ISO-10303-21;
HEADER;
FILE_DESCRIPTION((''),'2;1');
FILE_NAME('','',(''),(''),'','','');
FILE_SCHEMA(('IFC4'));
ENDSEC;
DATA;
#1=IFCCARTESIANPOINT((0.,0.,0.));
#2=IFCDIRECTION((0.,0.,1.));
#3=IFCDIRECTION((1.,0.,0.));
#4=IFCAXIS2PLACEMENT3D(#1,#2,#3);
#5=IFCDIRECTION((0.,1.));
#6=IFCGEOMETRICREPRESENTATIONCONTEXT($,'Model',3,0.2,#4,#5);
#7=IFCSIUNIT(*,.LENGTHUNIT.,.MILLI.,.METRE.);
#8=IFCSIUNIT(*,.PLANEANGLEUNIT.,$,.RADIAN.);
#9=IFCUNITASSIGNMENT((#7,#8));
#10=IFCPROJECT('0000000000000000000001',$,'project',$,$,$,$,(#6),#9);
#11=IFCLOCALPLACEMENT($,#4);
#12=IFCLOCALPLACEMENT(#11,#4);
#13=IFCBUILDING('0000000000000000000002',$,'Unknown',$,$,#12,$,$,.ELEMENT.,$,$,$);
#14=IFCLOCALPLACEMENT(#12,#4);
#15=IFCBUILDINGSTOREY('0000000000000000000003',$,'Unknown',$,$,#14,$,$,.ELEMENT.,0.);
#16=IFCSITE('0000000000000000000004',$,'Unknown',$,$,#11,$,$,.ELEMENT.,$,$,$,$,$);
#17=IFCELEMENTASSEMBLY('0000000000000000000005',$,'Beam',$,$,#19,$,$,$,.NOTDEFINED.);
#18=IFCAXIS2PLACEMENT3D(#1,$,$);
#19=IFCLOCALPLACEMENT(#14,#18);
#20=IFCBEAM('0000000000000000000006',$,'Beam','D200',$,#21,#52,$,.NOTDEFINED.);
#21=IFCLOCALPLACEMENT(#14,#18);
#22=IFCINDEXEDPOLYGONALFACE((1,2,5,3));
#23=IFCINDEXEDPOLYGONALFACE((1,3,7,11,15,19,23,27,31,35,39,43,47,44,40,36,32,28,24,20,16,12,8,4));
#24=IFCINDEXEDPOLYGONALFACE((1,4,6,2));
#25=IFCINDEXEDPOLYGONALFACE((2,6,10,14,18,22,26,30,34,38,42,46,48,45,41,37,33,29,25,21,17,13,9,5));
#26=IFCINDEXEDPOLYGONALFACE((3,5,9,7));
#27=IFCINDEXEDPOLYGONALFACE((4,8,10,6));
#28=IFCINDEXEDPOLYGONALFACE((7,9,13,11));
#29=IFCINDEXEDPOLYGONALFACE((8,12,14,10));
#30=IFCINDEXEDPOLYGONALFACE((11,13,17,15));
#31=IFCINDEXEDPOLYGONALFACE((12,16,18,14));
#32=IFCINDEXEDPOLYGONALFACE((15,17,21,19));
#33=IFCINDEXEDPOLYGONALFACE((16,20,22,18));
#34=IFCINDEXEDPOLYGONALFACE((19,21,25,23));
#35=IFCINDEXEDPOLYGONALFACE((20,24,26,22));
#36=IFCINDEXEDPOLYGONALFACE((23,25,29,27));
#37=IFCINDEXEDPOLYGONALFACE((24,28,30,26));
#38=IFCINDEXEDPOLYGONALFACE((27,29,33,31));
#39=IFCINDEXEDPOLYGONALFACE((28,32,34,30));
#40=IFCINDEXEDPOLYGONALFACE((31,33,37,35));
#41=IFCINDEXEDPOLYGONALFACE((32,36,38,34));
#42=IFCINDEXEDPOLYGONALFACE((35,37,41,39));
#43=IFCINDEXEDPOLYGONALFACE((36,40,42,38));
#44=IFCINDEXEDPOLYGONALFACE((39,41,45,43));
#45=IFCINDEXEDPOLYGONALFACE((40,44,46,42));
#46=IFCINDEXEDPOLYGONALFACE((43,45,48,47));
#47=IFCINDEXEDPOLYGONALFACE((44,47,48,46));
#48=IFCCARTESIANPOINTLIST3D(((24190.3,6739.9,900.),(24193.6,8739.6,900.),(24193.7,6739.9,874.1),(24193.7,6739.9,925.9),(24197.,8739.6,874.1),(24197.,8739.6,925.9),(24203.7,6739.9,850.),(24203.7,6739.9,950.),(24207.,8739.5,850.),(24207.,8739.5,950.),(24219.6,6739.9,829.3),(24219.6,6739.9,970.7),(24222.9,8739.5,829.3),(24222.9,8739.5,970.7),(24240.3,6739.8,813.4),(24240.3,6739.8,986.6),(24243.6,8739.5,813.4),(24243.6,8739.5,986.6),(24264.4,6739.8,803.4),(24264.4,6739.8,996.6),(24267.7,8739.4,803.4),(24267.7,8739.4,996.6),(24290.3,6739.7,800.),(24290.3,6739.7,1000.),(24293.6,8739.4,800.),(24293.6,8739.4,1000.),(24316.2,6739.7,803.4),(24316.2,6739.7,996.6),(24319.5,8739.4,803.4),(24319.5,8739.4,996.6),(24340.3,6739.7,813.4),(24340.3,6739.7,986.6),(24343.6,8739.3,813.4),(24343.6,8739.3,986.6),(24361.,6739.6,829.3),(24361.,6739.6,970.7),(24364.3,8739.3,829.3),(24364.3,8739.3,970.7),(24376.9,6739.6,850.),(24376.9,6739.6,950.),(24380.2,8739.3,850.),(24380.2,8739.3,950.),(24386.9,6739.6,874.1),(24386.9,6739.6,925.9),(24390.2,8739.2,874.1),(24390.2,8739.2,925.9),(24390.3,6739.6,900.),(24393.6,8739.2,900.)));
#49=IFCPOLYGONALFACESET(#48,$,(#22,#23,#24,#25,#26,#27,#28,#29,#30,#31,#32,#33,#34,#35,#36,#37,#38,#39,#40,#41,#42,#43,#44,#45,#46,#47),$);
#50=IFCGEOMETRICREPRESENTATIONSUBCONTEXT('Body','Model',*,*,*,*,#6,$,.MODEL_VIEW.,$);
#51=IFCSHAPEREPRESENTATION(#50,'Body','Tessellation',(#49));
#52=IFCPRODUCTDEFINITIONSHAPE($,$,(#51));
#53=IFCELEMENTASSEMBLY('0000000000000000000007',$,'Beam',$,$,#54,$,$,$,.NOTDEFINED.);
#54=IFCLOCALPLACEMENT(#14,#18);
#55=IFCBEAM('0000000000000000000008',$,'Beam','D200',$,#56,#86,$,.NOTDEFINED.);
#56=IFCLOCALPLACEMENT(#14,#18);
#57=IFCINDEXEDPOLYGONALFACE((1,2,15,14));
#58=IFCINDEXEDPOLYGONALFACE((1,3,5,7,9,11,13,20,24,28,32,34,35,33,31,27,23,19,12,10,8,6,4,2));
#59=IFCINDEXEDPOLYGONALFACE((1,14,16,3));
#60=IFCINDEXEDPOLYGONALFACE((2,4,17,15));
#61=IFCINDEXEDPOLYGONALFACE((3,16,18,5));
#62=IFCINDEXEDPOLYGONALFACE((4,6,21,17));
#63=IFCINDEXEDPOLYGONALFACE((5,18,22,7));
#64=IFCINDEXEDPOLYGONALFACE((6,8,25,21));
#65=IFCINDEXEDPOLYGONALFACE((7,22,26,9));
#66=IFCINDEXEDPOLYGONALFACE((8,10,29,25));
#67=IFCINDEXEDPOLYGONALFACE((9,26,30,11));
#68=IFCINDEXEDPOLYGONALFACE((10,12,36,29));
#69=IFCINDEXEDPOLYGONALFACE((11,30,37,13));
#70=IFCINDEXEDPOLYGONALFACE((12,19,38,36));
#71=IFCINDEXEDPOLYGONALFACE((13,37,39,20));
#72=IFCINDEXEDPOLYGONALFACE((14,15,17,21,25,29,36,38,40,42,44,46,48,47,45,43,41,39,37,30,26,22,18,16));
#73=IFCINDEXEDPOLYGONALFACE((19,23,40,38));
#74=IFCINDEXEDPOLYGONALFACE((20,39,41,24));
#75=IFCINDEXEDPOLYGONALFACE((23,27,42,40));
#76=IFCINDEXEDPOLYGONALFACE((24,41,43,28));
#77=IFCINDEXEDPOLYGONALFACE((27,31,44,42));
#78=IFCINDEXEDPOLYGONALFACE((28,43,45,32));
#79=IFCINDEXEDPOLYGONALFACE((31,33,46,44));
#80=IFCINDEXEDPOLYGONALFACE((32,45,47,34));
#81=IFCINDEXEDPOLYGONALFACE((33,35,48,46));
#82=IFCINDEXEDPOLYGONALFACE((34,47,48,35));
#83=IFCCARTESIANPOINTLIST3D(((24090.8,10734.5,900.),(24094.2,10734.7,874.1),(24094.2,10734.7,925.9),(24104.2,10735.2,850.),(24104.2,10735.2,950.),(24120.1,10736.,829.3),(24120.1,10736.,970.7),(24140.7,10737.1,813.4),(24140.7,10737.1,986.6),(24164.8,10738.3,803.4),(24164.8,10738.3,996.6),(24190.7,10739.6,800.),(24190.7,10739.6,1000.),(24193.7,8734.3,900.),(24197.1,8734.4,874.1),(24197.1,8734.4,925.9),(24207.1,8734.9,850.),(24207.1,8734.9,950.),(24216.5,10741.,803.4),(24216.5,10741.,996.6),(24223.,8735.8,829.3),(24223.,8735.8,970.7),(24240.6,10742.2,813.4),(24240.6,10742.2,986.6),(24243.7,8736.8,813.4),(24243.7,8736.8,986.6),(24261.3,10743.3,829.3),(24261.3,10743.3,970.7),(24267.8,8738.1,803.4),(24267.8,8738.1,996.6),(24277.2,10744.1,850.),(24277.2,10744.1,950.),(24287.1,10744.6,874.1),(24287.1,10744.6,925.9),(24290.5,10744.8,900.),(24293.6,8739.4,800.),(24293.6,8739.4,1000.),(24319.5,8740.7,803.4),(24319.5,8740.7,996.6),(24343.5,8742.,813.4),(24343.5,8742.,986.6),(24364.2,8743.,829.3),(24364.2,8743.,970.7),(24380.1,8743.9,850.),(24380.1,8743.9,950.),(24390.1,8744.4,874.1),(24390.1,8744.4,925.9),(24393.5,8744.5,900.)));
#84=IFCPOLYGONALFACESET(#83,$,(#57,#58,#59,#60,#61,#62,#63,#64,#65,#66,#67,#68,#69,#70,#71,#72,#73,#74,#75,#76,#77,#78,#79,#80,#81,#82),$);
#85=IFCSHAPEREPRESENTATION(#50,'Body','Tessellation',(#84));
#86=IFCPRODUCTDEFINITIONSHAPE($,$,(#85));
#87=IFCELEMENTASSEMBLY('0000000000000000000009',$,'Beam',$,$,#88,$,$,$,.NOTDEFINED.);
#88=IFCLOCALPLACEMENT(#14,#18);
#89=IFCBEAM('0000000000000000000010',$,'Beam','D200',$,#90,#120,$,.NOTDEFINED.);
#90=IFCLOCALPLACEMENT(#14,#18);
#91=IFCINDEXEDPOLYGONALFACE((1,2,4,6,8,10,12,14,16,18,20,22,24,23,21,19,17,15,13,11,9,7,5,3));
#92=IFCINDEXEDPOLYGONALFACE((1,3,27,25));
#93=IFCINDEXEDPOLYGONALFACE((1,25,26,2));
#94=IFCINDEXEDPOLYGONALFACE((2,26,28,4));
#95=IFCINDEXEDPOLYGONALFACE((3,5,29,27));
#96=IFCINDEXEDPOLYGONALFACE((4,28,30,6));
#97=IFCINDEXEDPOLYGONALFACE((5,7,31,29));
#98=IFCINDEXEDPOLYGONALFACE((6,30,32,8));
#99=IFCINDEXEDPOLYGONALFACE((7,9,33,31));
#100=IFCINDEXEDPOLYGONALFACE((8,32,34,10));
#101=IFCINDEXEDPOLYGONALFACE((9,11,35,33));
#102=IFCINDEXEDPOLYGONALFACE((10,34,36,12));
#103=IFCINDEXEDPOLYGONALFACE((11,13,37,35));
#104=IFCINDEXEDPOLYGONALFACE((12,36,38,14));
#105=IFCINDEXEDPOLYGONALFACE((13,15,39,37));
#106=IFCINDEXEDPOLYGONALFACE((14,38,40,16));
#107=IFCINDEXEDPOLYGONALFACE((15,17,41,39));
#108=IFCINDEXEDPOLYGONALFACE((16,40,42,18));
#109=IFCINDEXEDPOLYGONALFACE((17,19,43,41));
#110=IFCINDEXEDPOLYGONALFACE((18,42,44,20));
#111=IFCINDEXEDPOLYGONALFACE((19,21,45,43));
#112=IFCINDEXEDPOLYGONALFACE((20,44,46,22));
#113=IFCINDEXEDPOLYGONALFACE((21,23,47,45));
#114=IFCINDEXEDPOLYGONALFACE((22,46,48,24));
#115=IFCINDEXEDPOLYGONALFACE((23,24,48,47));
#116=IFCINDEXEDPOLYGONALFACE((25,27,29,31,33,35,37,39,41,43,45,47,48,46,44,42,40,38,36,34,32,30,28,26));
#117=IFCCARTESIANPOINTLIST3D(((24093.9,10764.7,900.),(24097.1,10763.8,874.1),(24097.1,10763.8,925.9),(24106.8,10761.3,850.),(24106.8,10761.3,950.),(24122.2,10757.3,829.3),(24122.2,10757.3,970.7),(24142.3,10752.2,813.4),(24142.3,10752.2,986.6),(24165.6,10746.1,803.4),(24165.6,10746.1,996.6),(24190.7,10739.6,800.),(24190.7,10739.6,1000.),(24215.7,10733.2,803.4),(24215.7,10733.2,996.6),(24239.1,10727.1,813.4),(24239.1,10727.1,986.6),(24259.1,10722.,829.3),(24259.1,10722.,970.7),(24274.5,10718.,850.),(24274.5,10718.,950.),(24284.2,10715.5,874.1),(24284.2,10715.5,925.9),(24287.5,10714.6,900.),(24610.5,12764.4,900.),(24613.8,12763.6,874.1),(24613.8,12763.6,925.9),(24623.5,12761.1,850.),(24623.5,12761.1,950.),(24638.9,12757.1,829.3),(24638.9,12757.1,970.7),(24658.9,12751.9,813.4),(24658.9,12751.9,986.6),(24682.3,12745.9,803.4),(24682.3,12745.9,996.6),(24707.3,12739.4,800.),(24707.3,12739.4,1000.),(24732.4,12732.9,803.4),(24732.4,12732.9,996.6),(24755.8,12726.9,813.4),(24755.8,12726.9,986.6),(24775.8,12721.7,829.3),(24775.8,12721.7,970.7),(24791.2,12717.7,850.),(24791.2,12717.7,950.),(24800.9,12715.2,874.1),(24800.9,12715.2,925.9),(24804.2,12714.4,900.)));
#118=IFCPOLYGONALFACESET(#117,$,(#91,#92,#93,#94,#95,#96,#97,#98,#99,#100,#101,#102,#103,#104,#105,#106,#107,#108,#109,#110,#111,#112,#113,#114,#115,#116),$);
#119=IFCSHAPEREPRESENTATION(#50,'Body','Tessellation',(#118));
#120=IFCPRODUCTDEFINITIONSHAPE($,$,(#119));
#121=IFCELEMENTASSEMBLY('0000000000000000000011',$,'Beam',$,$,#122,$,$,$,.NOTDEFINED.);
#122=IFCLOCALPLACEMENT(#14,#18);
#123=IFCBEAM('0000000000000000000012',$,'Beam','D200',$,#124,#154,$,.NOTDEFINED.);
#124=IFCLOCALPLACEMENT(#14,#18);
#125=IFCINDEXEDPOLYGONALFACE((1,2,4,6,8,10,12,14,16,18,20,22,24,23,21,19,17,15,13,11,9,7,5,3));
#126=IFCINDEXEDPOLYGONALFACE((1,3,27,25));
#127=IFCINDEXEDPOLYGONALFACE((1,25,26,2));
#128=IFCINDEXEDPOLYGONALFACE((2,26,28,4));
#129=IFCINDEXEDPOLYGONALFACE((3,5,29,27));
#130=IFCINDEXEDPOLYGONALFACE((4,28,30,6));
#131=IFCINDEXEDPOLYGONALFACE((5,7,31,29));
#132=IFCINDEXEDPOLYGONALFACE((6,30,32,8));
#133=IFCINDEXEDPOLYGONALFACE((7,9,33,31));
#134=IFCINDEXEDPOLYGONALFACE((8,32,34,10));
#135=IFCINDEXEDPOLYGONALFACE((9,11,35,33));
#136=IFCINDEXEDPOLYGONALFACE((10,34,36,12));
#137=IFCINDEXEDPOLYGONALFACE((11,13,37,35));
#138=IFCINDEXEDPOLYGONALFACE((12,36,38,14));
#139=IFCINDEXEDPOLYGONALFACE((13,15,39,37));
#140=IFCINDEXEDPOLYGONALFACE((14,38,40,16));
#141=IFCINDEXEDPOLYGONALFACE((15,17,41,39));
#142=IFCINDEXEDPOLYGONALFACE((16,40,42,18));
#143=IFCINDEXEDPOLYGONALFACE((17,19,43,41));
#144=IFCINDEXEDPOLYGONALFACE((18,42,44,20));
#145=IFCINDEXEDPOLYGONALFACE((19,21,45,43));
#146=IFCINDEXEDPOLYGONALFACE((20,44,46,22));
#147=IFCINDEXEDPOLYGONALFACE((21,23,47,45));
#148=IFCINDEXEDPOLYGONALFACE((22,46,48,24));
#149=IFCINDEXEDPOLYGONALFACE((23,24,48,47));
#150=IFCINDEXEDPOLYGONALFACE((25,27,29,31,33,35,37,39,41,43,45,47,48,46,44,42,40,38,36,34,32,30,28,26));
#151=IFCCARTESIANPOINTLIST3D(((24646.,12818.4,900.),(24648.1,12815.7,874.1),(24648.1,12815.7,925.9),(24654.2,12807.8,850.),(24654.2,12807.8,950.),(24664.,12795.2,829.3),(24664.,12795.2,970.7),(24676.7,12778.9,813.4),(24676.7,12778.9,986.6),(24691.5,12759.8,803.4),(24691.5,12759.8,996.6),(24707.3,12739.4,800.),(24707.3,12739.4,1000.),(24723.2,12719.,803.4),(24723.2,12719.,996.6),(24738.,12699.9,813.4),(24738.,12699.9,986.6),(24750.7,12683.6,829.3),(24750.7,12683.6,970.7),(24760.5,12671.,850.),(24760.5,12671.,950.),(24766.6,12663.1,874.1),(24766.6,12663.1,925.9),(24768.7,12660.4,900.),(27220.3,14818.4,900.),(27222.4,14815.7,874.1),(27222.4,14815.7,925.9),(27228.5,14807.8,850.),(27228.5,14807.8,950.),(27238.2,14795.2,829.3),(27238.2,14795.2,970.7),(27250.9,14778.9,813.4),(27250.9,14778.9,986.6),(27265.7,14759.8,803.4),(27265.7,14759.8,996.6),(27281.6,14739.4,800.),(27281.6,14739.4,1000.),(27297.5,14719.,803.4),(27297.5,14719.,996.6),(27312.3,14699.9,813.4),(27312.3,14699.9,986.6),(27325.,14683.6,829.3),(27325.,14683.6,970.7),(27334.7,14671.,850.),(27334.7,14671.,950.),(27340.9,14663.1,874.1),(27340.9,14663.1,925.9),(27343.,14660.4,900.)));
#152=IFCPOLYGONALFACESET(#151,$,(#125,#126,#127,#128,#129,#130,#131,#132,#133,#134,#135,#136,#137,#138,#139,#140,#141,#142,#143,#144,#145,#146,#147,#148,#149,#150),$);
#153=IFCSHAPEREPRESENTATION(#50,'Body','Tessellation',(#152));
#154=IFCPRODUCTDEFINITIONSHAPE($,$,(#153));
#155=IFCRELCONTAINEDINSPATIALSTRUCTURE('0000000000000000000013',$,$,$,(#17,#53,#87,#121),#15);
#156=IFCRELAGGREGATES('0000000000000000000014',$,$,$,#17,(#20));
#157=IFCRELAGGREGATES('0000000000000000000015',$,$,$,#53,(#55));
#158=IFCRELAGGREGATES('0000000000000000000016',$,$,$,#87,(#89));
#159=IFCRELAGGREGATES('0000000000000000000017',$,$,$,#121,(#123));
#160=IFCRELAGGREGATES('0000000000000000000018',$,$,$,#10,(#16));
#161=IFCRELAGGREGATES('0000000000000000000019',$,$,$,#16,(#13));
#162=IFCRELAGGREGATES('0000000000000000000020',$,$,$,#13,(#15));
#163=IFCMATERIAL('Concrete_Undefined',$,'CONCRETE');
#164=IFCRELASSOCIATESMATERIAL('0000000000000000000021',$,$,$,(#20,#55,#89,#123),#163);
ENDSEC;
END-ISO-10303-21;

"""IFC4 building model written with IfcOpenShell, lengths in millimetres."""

from ifc_helpers import new_model, si_unit, direction, frame, origin_with_axes, place, context, subcontext, project, spatial, line, indexed_curve, outline, extrude, material, element, aggregate, save


model = new_model("IFC4")

# Units and contexts
model_context = context("Model", 3, precision=0.2, world=origin_with_axes(), true_north=direction((0.0, 1.0)))
body_context = subcontext(model_context, "Body", "Model", "MODEL_VIEW")
ifc_project = project(units=[si_unit("LENGTHUNIT", "METRE", prefix="MILLI"), si_unit("PLANEANGLEUNIT", "RADIAN")], contexts=[model_context])

# Site, building, storey
site_placement = place(None, origin_with_axes())
site = spatial("IfcSite", under=ifc_project, at=site_placement, Name="Unknown", CompositionType="ELEMENT")
building_placement = place(site_placement, origin_with_axes())
building = spatial("IfcBuilding", under=site, at=building_placement, Name="Unknown", CompositionType="ELEMENT")
storey_placement = place(building_placement, origin_with_axes())
storey = spatial("IfcBuildingStorey", under=building, at=storey_placement, Name="Unknown", CompositionType="ELEMENT", Elevation=0.0)

# Shared definitions
ifc_material = material(Name="Concrete_Undefined", Category="CONCRETE")

# Element assemblies, beams
assembly_1_placement = place(storey_placement, frame((24293.6, 8739.4, 900.0), z_axis=(-0.999999, 0.001662, 0.0), x_axis=(-0.001662, -0.999999, 0.0)))
assembly_1 = element("IfcElementAssembly", 1, at=assembly_1_placement, inside=storey, Name="Beam", PredefinedType="NOTDEFINED")
beam_1_placement = place(assembly_1_placement, origin_with_axes())
beam_1 = element("IfcBeam", 2, at=beam_1_placement, material=ifc_material, Name="Beam", Description="D200", PredefinedType="NOTDEFINED", context=body_context, shape_type="SolidModel", body=[
    extrude(outline(indexed_curve([(100.0, 0.0), (96.6, 25.9), (86.6, 50.0), (70.7, 70.7), (50.0, 86.6), (25.9, 96.6), (0.0, 100.0), (-25.9, 96.6), (-50.0, 86.6), (-70.7, 70.7), (-86.6, 50.0), (-96.6, 25.9), (-100.0, 0.0), (-96.6, -25.9), (-86.6, -50.0), (-70.7, -70.7), (-50.0, -86.6), (-25.9, -96.6), (0.0, -100.0), (25.9, -96.6), (50.0, -86.6), (70.7, -70.7), (86.6, -50.0), (96.6, -25.9)], segments=[line(1, 2, 3, 4, 5, 6, 7, 8, 9, 10, 11, 12, 13, 14, 15, 16, 17, 18, 19, 20, 21, 22, 23, 24, 1)])), frame((0.0, 0.0, 0.0), z_axis=(-1.0, 0.0, 0.0), x_axis=(0.0, 0.0, 1.0)), (0.0, 0.0, -1.0), 1999.7),
])
aggregate(assembly_1, [beam_1])
assembly_2_placement = place(storey_placement, frame((24190.7, 10739.6, 900.0), z_axis=(-0.998678, -0.051393, 0.0), x_axis=(0.051393, -0.998678, 0.0)))
assembly_2 = element("IfcElementAssembly", 3, at=assembly_2_placement, inside=storey, Name="Beam", PredefinedType="NOTDEFINED")
beam_2_placement = place(assembly_2_placement, origin_with_axes())
beam_2 = element("IfcBeam", 4, at=beam_2_placement, material=ifc_material, Name="Beam", Description="D200", PredefinedType="NOTDEFINED", context=body_context, shape_type="SolidModel", body=[
    extrude(outline(indexed_curve([(100.0, 0.0), (96.6, 25.9), (86.6, 50.0), (70.7, 70.7), (50.0, 86.6), (25.9, 96.6), (0.0, 100.0), (-25.9, 96.6), (-50.0, 86.6), (-70.7, 70.7), (-86.6, 50.0), (-96.6, 25.9), (-100.0, 0.0), (-96.6, -25.9), (-86.6, -50.0), (-70.7, -70.7), (-50.0, -86.6), (-25.9, -96.6), (0.0, -100.0), (25.9, -96.6), (50.0, -86.6), (70.7, -70.7), (86.6, -50.0), (96.6, -25.9)], segments=[line(1, 2, 3, 4, 5, 6, 7, 8, 9, 10, 11, 12, 13, 14, 15, 16, 17, 18, 19, 20, 21, 22, 23, 24, 1)])), frame((0.0, 0.0, 0.0), z_axis=(-1.0, 0.0, 0.0), x_axis=(0.0, 0.0, 1.0)), (0.0, 0.0, -1.0), 2002.9),
])
aggregate(assembly_2, [beam_2])
assembly_3_placement = place(storey_placement, frame((24707.3, 12739.4, 900.0), z_axis=(-0.968206, 0.250153, 0.0), x_axis=(-0.250153, -0.968206, 0.0)))
assembly_3 = element("IfcElementAssembly", 5, at=assembly_3_placement, inside=storey, Name="Beam", PredefinedType="NOTDEFINED")
beam_3_placement = place(assembly_3_placement, origin_with_axes())
beam_3 = element("IfcBeam", 6, at=beam_3_placement, material=ifc_material, Name="Beam", Description="D200", PredefinedType="NOTDEFINED", context=body_context, shape_type="SolidModel", body=[
    extrude(outline(indexed_curve([(100.0, 0.0), (96.6, 25.9), (86.6, 50.0), (70.7, 70.7), (50.0, 86.6), (25.9, 96.6), (0.0, 100.0), (-25.9, 96.6), (-50.0, 86.6), (-70.7, 70.7), (-86.6, 50.0), (-96.6, 25.9), (-100.0, 0.0), (-96.6, -25.9), (-86.6, -50.0), (-70.7, -70.7), (-50.0, -86.6), (-25.9, -96.6), (0.0, -100.0), (25.9, -96.6), (50.0, -86.6), (70.7, -70.7), (86.6, -50.0), (96.6, -25.9)], segments=[line(1, 2, 3, 4, 5, 6, 7, 8, 9, 10, 11, 12, 13, 14, 15, 16, 17, 18, 19, 20, 21, 22, 23, 24, 1)])), frame((0.0, 0.0, 0.0), z_axis=(-1.0, 0.0, 0.0), x_axis=(0.0, 0.0, 1.0)), (0.0, 0.0, -1.0), 2065.4),
])
aggregate(assembly_3, [beam_3])
assembly_4_placement = place(storey_placement, frame((27281.6, 14739.4, 900.0), z_axis=(-0.613518, 0.789681, 0.0), x_axis=(-0.789681, -0.613518, 0.0)))
assembly_4 = element("IfcElementAssembly", 7, at=assembly_4_placement, inside=storey, Name="Beam", PredefinedType="NOTDEFINED")
beam_4_placement = place(assembly_4_placement, origin_with_axes())
beam_4 = element("IfcBeam", 8, at=beam_4_placement, material=ifc_material, Name="Beam", Description="D200", PredefinedType="NOTDEFINED", context=body_context, shape_type="SolidModel", body=[
    extrude(outline(indexed_curve([(100.0, 0.0), (96.6, 25.9), (86.6, 50.0), (70.7, 70.7), (50.0, 86.6), (25.9, 96.6), (0.0, 100.0), (-25.9, 96.6), (-50.0, 86.6), (-70.7, 70.7), (-86.6, 50.0), (-96.6, 25.9), (-100.0, 0.0), (-96.6, -25.9), (-86.6, -50.0), (-70.7, -70.7), (-50.0, -86.6), (-25.9, -96.6), (0.0, -100.0), (25.9, -96.6), (50.0, -86.6), (70.7, -70.7), (86.6, -50.0), (96.6, -25.9)], segments=[line(1, 2, 3, 4, 5, 6, 7, 8, 9, 10, 11, 12, 13, 14, 15, 16, 17, 18, 19, 20, 21, 22, 23, 24, 1)])), frame((0.0, 0.0, 0.0), z_axis=(-1.0, 0.0, 0.0), x_axis=(0.0, 0.0, 1.0)), (0.0, 0.0, -1.0), 3259.9),
])
aggregate(assembly_4, [beam_4])

save(model, "model.ifc")
